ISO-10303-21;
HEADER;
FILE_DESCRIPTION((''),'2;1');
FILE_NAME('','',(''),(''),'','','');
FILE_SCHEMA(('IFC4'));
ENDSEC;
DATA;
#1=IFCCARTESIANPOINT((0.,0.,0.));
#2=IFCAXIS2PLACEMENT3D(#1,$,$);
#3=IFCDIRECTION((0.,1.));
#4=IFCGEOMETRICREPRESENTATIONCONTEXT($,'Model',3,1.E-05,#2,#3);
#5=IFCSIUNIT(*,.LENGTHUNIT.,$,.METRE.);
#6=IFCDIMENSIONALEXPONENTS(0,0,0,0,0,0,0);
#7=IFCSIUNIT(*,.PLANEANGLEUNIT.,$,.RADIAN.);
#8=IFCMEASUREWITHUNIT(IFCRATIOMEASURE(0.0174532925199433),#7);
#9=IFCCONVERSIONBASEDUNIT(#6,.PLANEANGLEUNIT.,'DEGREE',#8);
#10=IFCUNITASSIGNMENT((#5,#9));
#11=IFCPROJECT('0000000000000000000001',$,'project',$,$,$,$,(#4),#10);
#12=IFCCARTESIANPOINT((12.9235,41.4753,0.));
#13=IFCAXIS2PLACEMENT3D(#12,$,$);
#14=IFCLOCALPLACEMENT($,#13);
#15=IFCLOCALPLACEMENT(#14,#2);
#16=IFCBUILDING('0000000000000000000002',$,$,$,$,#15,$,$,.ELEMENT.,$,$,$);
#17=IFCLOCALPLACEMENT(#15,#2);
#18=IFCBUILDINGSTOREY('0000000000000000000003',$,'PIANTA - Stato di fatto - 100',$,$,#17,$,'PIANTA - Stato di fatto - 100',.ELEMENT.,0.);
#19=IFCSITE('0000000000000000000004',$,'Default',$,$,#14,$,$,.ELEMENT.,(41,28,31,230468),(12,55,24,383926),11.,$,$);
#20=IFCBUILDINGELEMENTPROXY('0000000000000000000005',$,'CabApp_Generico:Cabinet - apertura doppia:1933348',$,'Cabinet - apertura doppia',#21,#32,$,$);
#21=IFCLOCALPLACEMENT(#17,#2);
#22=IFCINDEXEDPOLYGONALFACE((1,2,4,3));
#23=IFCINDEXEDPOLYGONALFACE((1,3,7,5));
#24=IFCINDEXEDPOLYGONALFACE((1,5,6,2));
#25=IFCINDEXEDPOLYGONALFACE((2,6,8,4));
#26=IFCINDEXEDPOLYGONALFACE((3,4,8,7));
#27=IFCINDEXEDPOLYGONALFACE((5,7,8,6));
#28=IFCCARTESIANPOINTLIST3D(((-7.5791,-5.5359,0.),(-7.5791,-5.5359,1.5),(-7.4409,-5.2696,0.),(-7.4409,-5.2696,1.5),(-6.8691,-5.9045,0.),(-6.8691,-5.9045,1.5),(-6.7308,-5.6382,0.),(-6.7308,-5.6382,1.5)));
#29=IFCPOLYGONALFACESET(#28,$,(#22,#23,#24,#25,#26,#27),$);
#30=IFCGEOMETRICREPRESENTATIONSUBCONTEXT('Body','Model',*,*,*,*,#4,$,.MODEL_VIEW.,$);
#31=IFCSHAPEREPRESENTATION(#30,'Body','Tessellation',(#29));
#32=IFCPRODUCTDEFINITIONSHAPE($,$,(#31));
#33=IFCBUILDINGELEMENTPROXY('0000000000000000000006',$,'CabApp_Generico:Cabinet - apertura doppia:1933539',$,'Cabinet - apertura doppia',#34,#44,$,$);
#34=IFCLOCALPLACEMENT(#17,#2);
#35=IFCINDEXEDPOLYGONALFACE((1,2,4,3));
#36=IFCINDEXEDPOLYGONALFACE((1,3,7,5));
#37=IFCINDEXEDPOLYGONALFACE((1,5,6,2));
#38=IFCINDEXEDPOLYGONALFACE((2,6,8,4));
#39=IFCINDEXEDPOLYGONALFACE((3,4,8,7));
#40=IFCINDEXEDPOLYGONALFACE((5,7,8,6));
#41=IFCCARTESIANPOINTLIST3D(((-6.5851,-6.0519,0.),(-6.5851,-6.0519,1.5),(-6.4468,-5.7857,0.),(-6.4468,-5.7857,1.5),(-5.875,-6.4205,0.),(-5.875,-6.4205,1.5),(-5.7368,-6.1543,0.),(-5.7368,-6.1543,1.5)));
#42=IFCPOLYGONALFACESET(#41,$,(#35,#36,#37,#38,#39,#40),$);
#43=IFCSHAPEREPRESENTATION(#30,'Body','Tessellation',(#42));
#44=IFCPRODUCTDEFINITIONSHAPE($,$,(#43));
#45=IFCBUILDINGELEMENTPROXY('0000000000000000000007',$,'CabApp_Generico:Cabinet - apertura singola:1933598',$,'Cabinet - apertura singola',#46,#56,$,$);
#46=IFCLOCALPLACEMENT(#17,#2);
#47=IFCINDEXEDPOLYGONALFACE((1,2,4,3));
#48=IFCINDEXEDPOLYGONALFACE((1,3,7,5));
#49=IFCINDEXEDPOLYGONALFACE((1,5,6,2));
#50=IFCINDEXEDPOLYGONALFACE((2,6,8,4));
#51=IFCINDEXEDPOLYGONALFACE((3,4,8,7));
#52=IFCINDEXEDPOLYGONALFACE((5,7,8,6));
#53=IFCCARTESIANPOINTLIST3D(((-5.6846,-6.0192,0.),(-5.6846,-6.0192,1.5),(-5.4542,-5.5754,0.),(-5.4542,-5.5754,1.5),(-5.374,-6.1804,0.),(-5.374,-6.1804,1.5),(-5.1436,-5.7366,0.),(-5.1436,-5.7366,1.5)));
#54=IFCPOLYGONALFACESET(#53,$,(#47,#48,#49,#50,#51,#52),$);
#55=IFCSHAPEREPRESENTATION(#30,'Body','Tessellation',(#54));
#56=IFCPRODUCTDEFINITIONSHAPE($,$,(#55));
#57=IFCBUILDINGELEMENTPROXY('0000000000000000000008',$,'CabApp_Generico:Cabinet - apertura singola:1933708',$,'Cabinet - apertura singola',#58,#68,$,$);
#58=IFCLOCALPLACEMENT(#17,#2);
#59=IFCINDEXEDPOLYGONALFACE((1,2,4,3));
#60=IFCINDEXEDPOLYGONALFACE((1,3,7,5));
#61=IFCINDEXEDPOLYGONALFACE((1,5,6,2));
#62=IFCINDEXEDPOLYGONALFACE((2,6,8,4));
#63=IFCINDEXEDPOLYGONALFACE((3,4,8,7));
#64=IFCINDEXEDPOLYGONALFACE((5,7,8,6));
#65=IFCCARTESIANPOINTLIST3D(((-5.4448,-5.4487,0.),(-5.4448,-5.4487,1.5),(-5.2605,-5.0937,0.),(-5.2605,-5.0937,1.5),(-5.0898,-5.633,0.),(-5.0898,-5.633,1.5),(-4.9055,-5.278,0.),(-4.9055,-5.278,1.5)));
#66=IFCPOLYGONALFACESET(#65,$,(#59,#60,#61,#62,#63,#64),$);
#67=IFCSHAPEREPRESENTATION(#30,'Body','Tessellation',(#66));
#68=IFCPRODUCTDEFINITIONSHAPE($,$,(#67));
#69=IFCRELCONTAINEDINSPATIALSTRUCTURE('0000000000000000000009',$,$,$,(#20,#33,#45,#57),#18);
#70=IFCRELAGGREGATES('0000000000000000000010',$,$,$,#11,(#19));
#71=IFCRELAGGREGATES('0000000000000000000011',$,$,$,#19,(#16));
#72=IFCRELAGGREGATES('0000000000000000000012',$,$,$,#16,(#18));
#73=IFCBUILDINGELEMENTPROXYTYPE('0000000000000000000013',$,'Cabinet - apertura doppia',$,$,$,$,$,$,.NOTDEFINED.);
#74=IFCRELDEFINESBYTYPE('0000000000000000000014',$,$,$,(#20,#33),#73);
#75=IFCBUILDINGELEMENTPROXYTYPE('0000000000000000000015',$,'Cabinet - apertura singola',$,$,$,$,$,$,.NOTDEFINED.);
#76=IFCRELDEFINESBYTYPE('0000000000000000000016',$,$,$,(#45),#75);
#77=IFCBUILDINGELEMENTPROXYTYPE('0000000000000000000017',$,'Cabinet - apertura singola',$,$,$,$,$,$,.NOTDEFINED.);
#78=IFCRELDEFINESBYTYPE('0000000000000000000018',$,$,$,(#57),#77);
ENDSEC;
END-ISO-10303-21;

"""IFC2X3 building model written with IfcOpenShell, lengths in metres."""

from ifc_helpers import new_model, entity, si_unit, converted_unit, direction, frame, frame_2d, origin, origin_2d_with_axis, place, context, subcontext, project, spatial, rectangle, extrude, source, transform, mapped, type_object, type_shapes, element, save


model = new_model("IFC2X3")

# Units and contexts
model_context = context("Model", 3, precision=1e-05, world=origin(), true_north=direction((0.0, 1.0)))
body_context = subcontext(model_context, "Body", "Model", "MODEL_VIEW")
ifc_project = project(units=[si_unit("LENGTHUNIT", "METRE"), converted_unit("PLANEANGLEUNIT", "DEGREE", entity("IfcRatioMeasure", 0.0174532925199433), si_unit("PLANEANGLEUNIT", "RADIAN"), dimensions=[0, 0, 0, 0, 0, 0, 0])], contexts=[model_context])

# Site, building, storey
site_placement = place(None, frame((12.9235, 41.4753, 0.0)))
site = spatial("IfcSite", under=ifc_project, at=site_placement, Name="Default", CompositionType="ELEMENT", RefLatitude=(41, 28, 31, 230468), RefLongitude=(12, 55, 24, 383926), RefElevation=11.0)
building_placement = place(site_placement, origin())
building = spatial("IfcBuilding", under=site, at=building_placement, CompositionType="ELEMENT")
storey_placement = place(building_placement, origin())
storey = spatial("IfcBuildingStorey", under=building, at=storey_placement, Name="PIANTA - Stato di fatto - 100", LongName="PIANTA - Stato di fatto - 100", CompositionType="ELEMENT", Elevation=0.0)

# Building element proxies
building_element_proxy_type_1 = type_object("IfcBuildingElementProxyType", Name="Cabinet - apertura doppia", PredefinedType="NOTDEFINED")
shared_shape_1 = source(origin(), body_context, "Body", "SweptSolid", [
    extrude(rectangle(XDim=0.3, YDim=0.8, at=origin_2d_with_axis()), frame((0.0, 0.0, 0.0), z_axis=(0.0, 0.0, 1.0), x_axis=(0.0, 1.0, 0.0)), (0.0, 0.0, 1.0), 1.5),
])
type_shapes(building_element_proxy_type_1, [shared_shape_1])
for number, where, z_axis, x_axis, name in (
    (1, (-7.155, -5.5871, 0.0), (0.0, 0.0, 1.0), (-0.887538, 0.460735, 0.0), "CabApp_Generico:Cabinet - apertura doppia:1933348"),
    (2, (-6.1609, -6.1031, 0.0), (0.0, 0.0, 1.0), (-0.887538, 0.460735, 0.0), "CabApp_Generico:Cabinet - apertura doppia:1933539"),
):
    element("IfcBuildingElementProxy", number, at=place(storey_placement, frame(where, z_axis=z_axis, x_axis=x_axis)), inside=storey, type_object=building_element_proxy_type_1, Name=name, ObjectType="Cabinet - apertura doppia", context=body_context, shape_type="MappedRepresentation", body=[
        mapped(shared_shape_1, transform((0.0, 0.0, 0.0), scale=1.0)),
    ])
building_element_proxy_type_2 = type_object("IfcBuildingElementProxyType", Name="Cabinet - apertura singola", PredefinedType="NOTDEFINED")
shared_shape_2 = source(origin(), body_context, "Body", "SweptSolid", [
    extrude(rectangle(XDim=0.5, YDim=0.35, at=origin_2d_with_axis()), frame((0.0, 0.0, 0.0), z_axis=(0.0, 0.0, 1.0), x_axis=(-1.0, 0.0, 0.0)), (0.0, 0.0, 1.0), 1.5),
])
type_shapes(building_element_proxy_type_2, [shared_shape_2])
proxy_1_placement = place(storey_placement, frame((-5.4141, -5.8779, 0.0), z_axis=(0.0, 0.0, 1.0), x_axis=(-0.460735, -0.887538, 0.0)))
element("IfcBuildingElementProxy", 3, at=proxy_1_placement, inside=storey, type_object=building_element_proxy_type_2, Name="CabApp_Generico:Cabinet - apertura singola:1933598", ObjectType="Cabinet - apertura singola", context=body_context, shape_type="MappedRepresentation", body=[
    mapped(shared_shape_2, transform((0.0, 0.0, 0.0), scale=1.0)),
])
building_element_proxy_type_3 = type_object("IfcBuildingElementProxyType", Name="Cabinet - apertura singola", PredefinedType="NOTDEFINED")
shared_shape_3 = source(origin(), body_context, "Body", "SweptSolid", [
    extrude(rectangle(XDim=0.4, YDim=0.4, at=frame_2d((0.0, 0.0), x_axis=(1.0, 0.0))), frame((0.0, 0.0, 0.0), z_axis=(0.0, 0.0, 1.0), x_axis=(-1.0, 0.0, 0.0)), (0.0, 0.0, 1.0), 1.5),
])
type_shapes(building_element_proxy_type_3, [shared_shape_3])
proxy_2_placement = place(storey_placement, frame((-5.1752, -5.3634, 0.0), z_axis=(0.0, 0.0, 1.0), x_axis=(-0.460735, -0.887538, 0.0)))
element("IfcBuildingElementProxy", 4, at=proxy_2_placement, inside=storey, type_object=building_element_proxy_type_3, Name="CabApp_Generico:Cabinet - apertura singola:1933708", ObjectType="Cabinet - apertura singola", context=body_context, shape_type="MappedRepresentation", body=[
    mapped(shared_shape_3, transform((0.0, 0.0, 0.0), scale=1.0)),
])

save(model, "model.ifc")
